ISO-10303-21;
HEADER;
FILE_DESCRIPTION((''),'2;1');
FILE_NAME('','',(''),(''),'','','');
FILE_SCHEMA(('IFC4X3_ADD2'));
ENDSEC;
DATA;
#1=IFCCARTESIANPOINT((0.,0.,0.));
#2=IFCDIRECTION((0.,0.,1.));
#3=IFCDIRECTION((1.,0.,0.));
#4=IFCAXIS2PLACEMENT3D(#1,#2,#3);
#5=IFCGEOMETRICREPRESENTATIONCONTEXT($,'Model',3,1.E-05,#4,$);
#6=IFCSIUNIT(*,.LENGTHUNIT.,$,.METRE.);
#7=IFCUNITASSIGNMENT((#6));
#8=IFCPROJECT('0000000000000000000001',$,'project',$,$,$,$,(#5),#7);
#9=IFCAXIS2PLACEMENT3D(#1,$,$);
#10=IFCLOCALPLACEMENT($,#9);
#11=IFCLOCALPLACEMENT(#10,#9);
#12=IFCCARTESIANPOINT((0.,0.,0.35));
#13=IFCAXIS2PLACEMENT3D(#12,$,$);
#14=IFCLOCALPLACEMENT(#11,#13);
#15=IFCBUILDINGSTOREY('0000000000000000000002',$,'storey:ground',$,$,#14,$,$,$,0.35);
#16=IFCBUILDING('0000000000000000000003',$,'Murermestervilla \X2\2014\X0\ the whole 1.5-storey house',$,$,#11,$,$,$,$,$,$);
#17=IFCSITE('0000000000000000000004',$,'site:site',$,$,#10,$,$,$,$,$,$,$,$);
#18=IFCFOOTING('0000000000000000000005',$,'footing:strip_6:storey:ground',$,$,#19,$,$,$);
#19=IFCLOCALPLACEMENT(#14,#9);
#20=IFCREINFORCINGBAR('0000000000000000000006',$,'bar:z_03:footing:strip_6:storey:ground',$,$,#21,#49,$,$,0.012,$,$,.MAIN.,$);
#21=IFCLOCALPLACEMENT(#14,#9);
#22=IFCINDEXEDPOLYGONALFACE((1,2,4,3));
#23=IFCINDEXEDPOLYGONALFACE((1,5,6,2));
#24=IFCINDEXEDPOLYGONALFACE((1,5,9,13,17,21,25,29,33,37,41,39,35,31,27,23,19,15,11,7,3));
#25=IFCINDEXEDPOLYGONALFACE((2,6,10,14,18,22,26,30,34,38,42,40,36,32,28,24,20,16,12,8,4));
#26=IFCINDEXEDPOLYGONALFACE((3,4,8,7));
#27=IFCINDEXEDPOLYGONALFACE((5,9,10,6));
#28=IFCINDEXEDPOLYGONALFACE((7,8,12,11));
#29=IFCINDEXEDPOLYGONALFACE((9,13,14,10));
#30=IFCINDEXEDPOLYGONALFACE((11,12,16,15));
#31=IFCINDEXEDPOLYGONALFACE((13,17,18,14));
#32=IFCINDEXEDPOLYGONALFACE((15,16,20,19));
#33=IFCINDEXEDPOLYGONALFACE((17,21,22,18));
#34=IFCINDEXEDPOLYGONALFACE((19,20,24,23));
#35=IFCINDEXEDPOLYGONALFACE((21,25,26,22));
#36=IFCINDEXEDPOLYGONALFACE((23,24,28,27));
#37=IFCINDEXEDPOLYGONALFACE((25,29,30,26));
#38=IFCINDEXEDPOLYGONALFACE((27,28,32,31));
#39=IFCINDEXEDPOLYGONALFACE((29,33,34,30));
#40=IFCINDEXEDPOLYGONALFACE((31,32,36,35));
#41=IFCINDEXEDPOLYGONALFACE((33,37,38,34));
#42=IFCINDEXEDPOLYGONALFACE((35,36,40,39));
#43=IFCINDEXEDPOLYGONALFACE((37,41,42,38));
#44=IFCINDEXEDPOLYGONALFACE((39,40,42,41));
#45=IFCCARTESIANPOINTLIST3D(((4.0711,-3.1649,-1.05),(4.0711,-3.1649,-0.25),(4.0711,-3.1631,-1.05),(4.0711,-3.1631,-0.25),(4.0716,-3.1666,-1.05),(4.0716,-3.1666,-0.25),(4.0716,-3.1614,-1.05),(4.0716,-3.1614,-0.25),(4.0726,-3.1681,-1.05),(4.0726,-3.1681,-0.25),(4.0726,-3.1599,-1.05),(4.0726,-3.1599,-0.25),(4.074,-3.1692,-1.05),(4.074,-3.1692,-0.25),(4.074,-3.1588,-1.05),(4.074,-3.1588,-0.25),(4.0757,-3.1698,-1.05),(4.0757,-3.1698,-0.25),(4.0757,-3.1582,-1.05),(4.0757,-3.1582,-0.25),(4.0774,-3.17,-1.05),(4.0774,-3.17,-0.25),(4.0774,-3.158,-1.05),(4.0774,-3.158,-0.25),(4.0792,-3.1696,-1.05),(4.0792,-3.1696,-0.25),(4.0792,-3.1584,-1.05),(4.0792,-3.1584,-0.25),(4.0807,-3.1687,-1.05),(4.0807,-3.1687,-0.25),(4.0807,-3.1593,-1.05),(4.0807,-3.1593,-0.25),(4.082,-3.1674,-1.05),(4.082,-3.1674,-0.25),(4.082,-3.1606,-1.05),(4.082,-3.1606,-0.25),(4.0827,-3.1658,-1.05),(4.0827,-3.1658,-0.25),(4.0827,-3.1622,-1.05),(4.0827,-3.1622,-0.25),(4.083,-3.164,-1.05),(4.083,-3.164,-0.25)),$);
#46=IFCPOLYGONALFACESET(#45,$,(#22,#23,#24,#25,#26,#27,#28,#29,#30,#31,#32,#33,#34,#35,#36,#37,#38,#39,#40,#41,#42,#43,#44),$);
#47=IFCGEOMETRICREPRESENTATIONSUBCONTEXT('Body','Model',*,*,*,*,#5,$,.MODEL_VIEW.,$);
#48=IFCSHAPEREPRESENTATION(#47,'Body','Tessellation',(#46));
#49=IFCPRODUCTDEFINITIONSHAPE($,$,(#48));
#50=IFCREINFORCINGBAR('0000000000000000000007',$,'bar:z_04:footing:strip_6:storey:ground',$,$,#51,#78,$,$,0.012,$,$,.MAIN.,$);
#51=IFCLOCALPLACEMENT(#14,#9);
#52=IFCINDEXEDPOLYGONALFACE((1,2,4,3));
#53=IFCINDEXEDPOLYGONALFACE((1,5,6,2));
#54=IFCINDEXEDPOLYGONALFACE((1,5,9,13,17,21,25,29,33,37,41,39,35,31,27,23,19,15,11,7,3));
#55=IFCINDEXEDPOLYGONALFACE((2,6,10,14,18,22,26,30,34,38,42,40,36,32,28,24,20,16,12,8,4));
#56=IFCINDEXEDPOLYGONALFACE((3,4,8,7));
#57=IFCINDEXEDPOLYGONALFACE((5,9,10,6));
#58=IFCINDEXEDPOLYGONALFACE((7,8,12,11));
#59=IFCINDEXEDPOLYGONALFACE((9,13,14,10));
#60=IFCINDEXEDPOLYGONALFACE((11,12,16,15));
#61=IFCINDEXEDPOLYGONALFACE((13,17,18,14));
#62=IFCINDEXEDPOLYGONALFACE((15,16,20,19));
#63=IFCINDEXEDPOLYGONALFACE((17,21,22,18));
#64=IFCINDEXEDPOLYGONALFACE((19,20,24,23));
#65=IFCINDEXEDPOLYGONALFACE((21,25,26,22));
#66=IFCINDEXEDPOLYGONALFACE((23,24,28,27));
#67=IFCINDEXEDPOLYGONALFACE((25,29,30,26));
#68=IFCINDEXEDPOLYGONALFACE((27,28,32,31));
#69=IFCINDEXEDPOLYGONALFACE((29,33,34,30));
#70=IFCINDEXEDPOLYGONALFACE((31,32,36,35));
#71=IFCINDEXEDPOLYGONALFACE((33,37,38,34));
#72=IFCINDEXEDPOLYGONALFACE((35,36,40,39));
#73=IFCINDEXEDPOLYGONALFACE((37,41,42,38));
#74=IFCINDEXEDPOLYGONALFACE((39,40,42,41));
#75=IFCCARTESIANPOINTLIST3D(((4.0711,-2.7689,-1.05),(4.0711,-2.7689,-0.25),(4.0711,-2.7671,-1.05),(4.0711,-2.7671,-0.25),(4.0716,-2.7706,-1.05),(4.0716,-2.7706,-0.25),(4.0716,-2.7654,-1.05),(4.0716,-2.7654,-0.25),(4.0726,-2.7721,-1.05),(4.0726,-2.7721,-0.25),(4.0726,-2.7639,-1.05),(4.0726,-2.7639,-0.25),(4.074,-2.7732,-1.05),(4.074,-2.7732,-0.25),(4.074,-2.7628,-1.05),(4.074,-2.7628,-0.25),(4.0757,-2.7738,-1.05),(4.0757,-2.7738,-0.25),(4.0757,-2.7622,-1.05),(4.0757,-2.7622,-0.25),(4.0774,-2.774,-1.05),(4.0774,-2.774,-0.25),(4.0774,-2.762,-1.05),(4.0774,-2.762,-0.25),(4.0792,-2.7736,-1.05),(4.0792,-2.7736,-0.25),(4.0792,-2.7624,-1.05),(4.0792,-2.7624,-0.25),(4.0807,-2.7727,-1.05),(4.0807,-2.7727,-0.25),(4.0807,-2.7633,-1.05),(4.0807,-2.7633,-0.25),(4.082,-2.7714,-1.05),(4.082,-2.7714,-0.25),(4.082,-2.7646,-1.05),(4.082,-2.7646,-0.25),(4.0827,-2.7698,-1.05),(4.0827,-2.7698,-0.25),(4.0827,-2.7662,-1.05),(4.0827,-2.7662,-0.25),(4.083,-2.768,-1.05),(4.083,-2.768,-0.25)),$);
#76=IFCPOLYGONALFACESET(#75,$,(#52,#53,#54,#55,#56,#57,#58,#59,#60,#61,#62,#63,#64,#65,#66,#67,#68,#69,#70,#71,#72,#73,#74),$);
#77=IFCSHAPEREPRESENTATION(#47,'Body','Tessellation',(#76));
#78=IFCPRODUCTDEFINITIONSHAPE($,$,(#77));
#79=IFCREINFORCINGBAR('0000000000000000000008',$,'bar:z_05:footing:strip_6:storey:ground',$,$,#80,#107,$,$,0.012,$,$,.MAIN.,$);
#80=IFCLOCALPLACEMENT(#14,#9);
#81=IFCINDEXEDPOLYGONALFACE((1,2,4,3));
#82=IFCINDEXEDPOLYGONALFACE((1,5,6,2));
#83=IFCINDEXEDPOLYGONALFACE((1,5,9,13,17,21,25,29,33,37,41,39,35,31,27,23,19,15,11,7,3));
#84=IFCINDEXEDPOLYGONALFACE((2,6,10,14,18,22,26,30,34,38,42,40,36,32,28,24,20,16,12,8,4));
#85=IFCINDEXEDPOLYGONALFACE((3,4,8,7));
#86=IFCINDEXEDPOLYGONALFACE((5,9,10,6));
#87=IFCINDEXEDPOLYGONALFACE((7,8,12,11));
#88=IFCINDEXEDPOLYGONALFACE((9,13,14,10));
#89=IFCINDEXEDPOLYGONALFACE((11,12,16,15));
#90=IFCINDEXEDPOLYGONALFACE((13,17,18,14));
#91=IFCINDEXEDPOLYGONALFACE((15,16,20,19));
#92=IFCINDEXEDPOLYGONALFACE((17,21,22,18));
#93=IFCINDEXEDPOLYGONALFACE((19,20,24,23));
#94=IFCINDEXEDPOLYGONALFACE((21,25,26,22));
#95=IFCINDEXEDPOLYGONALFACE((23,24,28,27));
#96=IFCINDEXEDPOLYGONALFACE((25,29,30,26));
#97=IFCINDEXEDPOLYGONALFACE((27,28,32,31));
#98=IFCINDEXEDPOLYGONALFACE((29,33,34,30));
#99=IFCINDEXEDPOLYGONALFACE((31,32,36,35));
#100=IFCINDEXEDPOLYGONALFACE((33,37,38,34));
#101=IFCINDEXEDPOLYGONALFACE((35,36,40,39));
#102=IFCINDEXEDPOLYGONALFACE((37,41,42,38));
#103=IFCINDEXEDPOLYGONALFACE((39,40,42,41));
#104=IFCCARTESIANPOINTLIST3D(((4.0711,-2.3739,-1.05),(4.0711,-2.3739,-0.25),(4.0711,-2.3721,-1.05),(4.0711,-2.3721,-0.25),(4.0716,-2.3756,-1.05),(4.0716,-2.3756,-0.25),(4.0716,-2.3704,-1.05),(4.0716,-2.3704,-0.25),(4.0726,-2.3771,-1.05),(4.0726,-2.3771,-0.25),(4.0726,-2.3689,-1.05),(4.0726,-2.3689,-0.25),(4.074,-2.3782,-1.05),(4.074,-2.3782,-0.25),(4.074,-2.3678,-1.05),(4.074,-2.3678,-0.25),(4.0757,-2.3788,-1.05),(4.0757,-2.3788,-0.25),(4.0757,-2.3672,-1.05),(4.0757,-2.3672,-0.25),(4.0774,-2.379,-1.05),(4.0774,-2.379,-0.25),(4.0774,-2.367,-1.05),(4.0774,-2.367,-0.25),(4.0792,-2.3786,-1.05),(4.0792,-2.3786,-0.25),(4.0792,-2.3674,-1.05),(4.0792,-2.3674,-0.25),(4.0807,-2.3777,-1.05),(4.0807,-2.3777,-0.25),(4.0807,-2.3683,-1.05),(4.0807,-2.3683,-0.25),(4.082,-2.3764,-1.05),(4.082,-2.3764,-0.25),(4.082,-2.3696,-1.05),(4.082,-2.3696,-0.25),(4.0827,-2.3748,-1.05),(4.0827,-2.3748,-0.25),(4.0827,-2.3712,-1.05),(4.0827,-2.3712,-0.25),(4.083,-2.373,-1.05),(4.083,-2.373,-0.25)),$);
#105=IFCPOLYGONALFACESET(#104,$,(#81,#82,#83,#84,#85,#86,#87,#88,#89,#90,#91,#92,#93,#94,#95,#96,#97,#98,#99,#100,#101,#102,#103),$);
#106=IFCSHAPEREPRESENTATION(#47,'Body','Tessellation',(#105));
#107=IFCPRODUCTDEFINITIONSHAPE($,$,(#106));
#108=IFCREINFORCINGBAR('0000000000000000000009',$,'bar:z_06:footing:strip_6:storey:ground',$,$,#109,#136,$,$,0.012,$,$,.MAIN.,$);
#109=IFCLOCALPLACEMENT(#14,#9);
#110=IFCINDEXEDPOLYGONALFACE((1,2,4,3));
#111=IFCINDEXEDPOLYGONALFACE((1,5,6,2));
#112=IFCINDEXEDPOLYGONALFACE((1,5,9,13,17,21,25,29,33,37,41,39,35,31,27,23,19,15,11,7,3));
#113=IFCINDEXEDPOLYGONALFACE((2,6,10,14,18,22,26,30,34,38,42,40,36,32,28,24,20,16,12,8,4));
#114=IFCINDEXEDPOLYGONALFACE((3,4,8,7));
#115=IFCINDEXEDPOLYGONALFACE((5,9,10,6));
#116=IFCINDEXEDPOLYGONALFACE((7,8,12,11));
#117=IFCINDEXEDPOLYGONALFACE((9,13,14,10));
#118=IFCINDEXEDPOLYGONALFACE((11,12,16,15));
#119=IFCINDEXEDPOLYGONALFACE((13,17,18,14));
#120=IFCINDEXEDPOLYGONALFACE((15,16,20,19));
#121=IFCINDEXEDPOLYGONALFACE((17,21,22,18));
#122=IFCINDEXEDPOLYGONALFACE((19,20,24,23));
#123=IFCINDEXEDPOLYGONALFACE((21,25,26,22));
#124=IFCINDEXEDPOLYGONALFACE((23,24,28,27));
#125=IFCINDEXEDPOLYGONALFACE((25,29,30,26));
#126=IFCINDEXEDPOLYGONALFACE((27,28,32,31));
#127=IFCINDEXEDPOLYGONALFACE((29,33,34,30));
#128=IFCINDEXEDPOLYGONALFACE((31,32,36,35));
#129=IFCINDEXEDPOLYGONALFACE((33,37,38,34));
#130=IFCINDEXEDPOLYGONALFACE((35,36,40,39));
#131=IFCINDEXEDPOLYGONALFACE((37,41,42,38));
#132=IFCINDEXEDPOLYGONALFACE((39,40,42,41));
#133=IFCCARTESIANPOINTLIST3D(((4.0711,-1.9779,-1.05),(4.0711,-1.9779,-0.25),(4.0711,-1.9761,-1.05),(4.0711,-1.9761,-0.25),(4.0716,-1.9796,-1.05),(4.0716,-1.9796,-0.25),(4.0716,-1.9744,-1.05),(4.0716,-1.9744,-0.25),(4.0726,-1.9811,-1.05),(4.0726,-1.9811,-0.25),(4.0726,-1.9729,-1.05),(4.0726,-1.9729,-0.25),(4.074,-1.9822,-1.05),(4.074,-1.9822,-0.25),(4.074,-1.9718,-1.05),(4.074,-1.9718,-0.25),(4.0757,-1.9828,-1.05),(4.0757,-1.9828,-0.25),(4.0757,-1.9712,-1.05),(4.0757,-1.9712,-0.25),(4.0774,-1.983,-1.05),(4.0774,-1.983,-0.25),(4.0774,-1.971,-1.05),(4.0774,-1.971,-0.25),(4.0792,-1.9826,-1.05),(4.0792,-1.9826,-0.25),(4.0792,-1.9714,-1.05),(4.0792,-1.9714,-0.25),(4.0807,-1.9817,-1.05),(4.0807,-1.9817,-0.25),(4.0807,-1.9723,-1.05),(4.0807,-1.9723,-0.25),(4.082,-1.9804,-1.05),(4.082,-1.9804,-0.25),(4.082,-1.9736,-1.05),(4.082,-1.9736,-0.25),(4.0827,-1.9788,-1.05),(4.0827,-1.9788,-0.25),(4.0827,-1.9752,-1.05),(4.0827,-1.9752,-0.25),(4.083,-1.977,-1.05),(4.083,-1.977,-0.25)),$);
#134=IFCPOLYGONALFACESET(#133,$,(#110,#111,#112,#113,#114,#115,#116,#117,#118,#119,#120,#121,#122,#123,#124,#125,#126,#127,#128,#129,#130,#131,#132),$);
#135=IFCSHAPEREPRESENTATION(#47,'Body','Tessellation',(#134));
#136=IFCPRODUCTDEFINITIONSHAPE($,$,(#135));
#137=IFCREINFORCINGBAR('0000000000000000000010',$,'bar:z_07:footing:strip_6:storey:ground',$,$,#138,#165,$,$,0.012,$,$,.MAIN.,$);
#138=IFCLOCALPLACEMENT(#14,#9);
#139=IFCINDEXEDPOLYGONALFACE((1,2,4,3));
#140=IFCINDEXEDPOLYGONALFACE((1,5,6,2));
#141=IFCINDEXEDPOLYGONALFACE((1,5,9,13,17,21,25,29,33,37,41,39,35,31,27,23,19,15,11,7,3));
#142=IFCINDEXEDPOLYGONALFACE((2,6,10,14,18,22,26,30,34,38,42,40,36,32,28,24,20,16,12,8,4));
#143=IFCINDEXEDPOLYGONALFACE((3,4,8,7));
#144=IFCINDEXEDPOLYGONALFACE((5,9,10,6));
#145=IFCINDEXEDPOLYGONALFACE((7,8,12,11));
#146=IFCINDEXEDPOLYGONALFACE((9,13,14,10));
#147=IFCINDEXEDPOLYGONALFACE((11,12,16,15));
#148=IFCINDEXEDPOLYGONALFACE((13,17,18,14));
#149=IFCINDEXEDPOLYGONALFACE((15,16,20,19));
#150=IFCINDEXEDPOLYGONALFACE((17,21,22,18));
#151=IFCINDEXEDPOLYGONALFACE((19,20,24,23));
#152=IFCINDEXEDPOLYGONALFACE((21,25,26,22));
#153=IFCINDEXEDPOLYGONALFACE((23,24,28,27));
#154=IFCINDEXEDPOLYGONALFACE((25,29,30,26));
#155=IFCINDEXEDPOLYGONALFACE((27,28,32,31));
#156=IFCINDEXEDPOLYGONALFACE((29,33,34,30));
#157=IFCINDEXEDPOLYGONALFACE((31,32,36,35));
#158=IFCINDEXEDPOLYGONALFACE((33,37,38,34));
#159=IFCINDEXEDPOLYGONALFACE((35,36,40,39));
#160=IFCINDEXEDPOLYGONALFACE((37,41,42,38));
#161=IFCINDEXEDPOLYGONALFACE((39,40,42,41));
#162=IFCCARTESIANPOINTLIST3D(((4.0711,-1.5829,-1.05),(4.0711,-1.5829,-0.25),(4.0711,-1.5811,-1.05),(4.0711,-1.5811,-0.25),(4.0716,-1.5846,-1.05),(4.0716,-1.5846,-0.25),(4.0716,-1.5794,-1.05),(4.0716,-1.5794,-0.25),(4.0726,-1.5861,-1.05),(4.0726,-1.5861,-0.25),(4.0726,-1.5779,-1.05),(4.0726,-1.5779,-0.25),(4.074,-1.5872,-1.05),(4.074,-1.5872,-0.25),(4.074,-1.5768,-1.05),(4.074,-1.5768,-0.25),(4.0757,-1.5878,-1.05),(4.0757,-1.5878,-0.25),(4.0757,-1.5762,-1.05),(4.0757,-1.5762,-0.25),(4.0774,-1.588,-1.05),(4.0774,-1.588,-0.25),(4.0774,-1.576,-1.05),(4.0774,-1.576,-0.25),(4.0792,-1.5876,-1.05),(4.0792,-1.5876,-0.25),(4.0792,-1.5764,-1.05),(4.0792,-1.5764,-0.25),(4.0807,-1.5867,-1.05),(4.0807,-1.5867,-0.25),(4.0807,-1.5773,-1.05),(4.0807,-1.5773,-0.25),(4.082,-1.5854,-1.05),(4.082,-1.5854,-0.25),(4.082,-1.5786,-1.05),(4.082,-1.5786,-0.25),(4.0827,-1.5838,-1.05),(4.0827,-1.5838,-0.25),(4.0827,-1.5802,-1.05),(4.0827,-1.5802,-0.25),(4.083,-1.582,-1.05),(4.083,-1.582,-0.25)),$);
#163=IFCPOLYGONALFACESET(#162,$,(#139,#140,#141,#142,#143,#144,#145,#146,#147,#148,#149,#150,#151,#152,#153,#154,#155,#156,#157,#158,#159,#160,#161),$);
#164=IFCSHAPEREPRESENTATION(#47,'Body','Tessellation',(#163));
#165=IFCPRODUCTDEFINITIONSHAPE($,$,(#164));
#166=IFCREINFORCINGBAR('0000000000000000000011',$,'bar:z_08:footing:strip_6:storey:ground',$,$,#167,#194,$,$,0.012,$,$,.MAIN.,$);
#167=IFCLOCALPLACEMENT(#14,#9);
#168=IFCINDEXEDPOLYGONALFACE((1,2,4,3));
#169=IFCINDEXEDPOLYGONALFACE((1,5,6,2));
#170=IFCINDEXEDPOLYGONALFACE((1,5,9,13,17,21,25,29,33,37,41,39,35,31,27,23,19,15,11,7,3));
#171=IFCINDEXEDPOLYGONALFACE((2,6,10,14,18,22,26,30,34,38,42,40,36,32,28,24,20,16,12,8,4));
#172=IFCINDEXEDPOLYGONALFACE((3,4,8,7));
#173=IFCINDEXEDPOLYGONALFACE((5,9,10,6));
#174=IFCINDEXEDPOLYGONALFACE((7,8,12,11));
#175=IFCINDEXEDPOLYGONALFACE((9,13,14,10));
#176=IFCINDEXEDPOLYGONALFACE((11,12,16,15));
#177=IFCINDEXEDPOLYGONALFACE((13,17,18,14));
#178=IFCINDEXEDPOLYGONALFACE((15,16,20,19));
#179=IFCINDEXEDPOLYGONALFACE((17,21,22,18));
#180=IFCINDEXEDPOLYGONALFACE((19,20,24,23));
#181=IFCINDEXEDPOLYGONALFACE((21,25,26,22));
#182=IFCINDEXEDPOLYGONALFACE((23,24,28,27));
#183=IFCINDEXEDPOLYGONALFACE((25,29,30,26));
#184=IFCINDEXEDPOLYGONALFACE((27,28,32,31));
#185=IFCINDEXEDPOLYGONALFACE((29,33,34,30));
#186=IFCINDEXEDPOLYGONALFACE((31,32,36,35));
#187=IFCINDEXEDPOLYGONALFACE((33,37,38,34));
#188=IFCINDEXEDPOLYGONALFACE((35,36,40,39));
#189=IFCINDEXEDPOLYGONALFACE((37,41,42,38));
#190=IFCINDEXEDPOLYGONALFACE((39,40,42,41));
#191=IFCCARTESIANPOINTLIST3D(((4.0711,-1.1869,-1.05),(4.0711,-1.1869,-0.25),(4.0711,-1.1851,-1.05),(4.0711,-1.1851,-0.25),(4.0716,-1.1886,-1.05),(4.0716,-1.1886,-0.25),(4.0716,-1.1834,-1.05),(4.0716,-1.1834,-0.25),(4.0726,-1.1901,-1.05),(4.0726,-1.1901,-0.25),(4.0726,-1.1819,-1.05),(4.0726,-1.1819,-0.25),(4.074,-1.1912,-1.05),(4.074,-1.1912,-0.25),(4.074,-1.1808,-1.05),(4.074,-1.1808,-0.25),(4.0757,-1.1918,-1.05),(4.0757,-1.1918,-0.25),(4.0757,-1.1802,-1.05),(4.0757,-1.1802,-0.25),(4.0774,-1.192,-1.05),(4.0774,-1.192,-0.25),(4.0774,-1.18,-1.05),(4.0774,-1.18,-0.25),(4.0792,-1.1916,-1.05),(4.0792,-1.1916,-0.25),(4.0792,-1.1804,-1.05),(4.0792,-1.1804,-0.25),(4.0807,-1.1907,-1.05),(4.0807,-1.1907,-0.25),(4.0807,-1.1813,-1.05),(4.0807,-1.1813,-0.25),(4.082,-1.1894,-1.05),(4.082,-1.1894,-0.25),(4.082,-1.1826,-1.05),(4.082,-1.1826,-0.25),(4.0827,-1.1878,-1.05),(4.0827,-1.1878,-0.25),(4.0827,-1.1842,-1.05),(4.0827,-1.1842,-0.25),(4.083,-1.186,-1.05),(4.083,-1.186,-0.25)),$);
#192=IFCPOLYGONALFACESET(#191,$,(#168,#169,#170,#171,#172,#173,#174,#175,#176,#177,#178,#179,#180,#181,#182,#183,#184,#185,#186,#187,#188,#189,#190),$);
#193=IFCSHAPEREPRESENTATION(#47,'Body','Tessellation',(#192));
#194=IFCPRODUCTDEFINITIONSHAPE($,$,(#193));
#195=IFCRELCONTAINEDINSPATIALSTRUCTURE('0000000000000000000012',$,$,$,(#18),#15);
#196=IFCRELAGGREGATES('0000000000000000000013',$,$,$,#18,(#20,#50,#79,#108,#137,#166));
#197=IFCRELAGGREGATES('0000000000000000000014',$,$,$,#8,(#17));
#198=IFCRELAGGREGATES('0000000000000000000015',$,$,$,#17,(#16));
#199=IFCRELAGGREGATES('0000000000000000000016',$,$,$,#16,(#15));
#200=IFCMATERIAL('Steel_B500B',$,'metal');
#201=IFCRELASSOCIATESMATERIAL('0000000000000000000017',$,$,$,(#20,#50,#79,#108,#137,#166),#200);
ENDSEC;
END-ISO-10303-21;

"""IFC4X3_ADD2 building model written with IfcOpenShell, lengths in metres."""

from ifc_helpers import new_model, entity, si_unit, frame, origin, origin_with_axes, place, context, subcontext, project, spatial, material, element, aggregate, save


model = new_model("IFC4X3_ADD2")

# Units and contexts
model_context = context("Model", 3, precision=1e-05, world=origin_with_axes())
body_context = subcontext(model_context, "Body", "Model", "MODEL_VIEW")
ifc_project = project(units=[si_unit("LENGTHUNIT", "METRE")], contexts=[model_context])

# Site, building, storey
placement_1 = place(None, origin())
site = spatial("IfcSite", under=ifc_project, at=placement_1, Name="site:site")
building_placement = place(placement_1, origin())
building = spatial("IfcBuilding", under=site, at=building_placement, Name="Murermestervilla — the whole 1.5-storey house")
storey_placement = place(building_placement, frame((0.0, 0.0, 0.35)))
storey = spatial("IfcBuildingStorey", under=building, at=storey_placement, Name="storey:ground", Elevation=0.35)

# Footing, reinforcing bars
placement_2 = place(storey_placement, frame((0.0, 0.0, -0.35)))
footing_1 = element("IfcFooting", 1, at=placement_2, inside=storey, Name="footing:strip_6:storey:ground")
ifc_material = material(Name="Steel_B500B", Category="metal")
reinforcing_bar_1 = element("IfcReinforcingBar", 2, at=placement_1, material=ifc_material, Name="bar:z_03:footing:strip_6:storey:ground", NominalDiameter=0.012, PredefinedType="MAIN", context=body_context, shape_type="AdvancedSweptSolid", body=[
    entity("IfcSweptDiskSolid", entity("IfcPolyline", [entity("IfcCartesianPoint", [4.077, -3.164, -0.7]), entity("IfcCartesianPoint", [4.077, -3.164, 0.1])]), 0.006),
])
reinforcing_bar_2 = element("IfcReinforcingBar", 3, at=placement_1, material=ifc_material, Name="bar:z_04:footing:strip_6:storey:ground", NominalDiameter=0.012, PredefinedType="MAIN", context=body_context, shape_type="AdvancedSweptSolid", body=[
    entity("IfcSweptDiskSolid", entity("IfcPolyline", [entity("IfcCartesianPoint", [4.077, -2.768, -0.7]), entity("IfcCartesianPoint", [4.077, -2.768, 0.1])]), 0.006),
])
reinforcing_bar_3 = element("IfcReinforcingBar", 4, at=placement_1, material=ifc_material, Name="bar:z_05:footing:strip_6:storey:ground", NominalDiameter=0.012, PredefinedType="MAIN", context=body_context, shape_type="AdvancedSweptSolid", body=[
    entity("IfcSweptDiskSolid", entity("IfcPolyline", [entity("IfcCartesianPoint", [4.077, -2.373, -0.7]), entity("IfcCartesianPoint", [4.077, -2.373, 0.1])]), 0.006),
])
reinforcing_bar_4 = element("IfcReinforcingBar", 5, at=placement_1, material=ifc_material, Name="bar:z_06:footing:strip_6:storey:ground", NominalDiameter=0.012, PredefinedType="MAIN", context=body_context, shape_type="AdvancedSweptSolid", body=[
    entity("IfcSweptDiskSolid", entity("IfcPolyline", [entity("IfcCartesianPoint", [4.077, -1.977, -0.7]), entity("IfcCartesianPoint", [4.077, -1.977, 0.1])]), 0.006),
])
reinforcing_bar_5 = element("IfcReinforcingBar", 6, at=placement_1, material=ifc_material, Name="bar:z_07:footing:strip_6:storey:ground", NominalDiameter=0.012, PredefinedType="MAIN", context=body_context, shape_type="AdvancedSweptSolid", body=[
    entity("IfcSweptDiskSolid", entity("IfcPolyline", [entity("IfcCartesianPoint", [4.077, -1.582, -0.7]), entity("IfcCartesianPoint", [4.077, -1.582, 0.1])]), 0.006),
])
reinforcing_bar_6 = element("IfcReinforcingBar", 7, at=placement_1, material=ifc_material, Name="bar:z_08:footing:strip_6:storey:ground", NominalDiameter=0.012, PredefinedType="MAIN", context=body_context, shape_type="AdvancedSweptSolid", body=[
    entity("IfcSweptDiskSolid", entity("IfcPolyline", [entity("IfcCartesianPoint", [4.077, -1.186, -0.7]), entity("IfcCartesianPoint", [4.077, -1.186, 0.1])]), 0.006),
])
aggregate(footing_1, [reinforcing_bar_1, reinforcing_bar_2, reinforcing_bar_3, reinforcing_bar_4, reinforcing_bar_5, reinforcing_bar_6])

save(model, "model.ifc")
